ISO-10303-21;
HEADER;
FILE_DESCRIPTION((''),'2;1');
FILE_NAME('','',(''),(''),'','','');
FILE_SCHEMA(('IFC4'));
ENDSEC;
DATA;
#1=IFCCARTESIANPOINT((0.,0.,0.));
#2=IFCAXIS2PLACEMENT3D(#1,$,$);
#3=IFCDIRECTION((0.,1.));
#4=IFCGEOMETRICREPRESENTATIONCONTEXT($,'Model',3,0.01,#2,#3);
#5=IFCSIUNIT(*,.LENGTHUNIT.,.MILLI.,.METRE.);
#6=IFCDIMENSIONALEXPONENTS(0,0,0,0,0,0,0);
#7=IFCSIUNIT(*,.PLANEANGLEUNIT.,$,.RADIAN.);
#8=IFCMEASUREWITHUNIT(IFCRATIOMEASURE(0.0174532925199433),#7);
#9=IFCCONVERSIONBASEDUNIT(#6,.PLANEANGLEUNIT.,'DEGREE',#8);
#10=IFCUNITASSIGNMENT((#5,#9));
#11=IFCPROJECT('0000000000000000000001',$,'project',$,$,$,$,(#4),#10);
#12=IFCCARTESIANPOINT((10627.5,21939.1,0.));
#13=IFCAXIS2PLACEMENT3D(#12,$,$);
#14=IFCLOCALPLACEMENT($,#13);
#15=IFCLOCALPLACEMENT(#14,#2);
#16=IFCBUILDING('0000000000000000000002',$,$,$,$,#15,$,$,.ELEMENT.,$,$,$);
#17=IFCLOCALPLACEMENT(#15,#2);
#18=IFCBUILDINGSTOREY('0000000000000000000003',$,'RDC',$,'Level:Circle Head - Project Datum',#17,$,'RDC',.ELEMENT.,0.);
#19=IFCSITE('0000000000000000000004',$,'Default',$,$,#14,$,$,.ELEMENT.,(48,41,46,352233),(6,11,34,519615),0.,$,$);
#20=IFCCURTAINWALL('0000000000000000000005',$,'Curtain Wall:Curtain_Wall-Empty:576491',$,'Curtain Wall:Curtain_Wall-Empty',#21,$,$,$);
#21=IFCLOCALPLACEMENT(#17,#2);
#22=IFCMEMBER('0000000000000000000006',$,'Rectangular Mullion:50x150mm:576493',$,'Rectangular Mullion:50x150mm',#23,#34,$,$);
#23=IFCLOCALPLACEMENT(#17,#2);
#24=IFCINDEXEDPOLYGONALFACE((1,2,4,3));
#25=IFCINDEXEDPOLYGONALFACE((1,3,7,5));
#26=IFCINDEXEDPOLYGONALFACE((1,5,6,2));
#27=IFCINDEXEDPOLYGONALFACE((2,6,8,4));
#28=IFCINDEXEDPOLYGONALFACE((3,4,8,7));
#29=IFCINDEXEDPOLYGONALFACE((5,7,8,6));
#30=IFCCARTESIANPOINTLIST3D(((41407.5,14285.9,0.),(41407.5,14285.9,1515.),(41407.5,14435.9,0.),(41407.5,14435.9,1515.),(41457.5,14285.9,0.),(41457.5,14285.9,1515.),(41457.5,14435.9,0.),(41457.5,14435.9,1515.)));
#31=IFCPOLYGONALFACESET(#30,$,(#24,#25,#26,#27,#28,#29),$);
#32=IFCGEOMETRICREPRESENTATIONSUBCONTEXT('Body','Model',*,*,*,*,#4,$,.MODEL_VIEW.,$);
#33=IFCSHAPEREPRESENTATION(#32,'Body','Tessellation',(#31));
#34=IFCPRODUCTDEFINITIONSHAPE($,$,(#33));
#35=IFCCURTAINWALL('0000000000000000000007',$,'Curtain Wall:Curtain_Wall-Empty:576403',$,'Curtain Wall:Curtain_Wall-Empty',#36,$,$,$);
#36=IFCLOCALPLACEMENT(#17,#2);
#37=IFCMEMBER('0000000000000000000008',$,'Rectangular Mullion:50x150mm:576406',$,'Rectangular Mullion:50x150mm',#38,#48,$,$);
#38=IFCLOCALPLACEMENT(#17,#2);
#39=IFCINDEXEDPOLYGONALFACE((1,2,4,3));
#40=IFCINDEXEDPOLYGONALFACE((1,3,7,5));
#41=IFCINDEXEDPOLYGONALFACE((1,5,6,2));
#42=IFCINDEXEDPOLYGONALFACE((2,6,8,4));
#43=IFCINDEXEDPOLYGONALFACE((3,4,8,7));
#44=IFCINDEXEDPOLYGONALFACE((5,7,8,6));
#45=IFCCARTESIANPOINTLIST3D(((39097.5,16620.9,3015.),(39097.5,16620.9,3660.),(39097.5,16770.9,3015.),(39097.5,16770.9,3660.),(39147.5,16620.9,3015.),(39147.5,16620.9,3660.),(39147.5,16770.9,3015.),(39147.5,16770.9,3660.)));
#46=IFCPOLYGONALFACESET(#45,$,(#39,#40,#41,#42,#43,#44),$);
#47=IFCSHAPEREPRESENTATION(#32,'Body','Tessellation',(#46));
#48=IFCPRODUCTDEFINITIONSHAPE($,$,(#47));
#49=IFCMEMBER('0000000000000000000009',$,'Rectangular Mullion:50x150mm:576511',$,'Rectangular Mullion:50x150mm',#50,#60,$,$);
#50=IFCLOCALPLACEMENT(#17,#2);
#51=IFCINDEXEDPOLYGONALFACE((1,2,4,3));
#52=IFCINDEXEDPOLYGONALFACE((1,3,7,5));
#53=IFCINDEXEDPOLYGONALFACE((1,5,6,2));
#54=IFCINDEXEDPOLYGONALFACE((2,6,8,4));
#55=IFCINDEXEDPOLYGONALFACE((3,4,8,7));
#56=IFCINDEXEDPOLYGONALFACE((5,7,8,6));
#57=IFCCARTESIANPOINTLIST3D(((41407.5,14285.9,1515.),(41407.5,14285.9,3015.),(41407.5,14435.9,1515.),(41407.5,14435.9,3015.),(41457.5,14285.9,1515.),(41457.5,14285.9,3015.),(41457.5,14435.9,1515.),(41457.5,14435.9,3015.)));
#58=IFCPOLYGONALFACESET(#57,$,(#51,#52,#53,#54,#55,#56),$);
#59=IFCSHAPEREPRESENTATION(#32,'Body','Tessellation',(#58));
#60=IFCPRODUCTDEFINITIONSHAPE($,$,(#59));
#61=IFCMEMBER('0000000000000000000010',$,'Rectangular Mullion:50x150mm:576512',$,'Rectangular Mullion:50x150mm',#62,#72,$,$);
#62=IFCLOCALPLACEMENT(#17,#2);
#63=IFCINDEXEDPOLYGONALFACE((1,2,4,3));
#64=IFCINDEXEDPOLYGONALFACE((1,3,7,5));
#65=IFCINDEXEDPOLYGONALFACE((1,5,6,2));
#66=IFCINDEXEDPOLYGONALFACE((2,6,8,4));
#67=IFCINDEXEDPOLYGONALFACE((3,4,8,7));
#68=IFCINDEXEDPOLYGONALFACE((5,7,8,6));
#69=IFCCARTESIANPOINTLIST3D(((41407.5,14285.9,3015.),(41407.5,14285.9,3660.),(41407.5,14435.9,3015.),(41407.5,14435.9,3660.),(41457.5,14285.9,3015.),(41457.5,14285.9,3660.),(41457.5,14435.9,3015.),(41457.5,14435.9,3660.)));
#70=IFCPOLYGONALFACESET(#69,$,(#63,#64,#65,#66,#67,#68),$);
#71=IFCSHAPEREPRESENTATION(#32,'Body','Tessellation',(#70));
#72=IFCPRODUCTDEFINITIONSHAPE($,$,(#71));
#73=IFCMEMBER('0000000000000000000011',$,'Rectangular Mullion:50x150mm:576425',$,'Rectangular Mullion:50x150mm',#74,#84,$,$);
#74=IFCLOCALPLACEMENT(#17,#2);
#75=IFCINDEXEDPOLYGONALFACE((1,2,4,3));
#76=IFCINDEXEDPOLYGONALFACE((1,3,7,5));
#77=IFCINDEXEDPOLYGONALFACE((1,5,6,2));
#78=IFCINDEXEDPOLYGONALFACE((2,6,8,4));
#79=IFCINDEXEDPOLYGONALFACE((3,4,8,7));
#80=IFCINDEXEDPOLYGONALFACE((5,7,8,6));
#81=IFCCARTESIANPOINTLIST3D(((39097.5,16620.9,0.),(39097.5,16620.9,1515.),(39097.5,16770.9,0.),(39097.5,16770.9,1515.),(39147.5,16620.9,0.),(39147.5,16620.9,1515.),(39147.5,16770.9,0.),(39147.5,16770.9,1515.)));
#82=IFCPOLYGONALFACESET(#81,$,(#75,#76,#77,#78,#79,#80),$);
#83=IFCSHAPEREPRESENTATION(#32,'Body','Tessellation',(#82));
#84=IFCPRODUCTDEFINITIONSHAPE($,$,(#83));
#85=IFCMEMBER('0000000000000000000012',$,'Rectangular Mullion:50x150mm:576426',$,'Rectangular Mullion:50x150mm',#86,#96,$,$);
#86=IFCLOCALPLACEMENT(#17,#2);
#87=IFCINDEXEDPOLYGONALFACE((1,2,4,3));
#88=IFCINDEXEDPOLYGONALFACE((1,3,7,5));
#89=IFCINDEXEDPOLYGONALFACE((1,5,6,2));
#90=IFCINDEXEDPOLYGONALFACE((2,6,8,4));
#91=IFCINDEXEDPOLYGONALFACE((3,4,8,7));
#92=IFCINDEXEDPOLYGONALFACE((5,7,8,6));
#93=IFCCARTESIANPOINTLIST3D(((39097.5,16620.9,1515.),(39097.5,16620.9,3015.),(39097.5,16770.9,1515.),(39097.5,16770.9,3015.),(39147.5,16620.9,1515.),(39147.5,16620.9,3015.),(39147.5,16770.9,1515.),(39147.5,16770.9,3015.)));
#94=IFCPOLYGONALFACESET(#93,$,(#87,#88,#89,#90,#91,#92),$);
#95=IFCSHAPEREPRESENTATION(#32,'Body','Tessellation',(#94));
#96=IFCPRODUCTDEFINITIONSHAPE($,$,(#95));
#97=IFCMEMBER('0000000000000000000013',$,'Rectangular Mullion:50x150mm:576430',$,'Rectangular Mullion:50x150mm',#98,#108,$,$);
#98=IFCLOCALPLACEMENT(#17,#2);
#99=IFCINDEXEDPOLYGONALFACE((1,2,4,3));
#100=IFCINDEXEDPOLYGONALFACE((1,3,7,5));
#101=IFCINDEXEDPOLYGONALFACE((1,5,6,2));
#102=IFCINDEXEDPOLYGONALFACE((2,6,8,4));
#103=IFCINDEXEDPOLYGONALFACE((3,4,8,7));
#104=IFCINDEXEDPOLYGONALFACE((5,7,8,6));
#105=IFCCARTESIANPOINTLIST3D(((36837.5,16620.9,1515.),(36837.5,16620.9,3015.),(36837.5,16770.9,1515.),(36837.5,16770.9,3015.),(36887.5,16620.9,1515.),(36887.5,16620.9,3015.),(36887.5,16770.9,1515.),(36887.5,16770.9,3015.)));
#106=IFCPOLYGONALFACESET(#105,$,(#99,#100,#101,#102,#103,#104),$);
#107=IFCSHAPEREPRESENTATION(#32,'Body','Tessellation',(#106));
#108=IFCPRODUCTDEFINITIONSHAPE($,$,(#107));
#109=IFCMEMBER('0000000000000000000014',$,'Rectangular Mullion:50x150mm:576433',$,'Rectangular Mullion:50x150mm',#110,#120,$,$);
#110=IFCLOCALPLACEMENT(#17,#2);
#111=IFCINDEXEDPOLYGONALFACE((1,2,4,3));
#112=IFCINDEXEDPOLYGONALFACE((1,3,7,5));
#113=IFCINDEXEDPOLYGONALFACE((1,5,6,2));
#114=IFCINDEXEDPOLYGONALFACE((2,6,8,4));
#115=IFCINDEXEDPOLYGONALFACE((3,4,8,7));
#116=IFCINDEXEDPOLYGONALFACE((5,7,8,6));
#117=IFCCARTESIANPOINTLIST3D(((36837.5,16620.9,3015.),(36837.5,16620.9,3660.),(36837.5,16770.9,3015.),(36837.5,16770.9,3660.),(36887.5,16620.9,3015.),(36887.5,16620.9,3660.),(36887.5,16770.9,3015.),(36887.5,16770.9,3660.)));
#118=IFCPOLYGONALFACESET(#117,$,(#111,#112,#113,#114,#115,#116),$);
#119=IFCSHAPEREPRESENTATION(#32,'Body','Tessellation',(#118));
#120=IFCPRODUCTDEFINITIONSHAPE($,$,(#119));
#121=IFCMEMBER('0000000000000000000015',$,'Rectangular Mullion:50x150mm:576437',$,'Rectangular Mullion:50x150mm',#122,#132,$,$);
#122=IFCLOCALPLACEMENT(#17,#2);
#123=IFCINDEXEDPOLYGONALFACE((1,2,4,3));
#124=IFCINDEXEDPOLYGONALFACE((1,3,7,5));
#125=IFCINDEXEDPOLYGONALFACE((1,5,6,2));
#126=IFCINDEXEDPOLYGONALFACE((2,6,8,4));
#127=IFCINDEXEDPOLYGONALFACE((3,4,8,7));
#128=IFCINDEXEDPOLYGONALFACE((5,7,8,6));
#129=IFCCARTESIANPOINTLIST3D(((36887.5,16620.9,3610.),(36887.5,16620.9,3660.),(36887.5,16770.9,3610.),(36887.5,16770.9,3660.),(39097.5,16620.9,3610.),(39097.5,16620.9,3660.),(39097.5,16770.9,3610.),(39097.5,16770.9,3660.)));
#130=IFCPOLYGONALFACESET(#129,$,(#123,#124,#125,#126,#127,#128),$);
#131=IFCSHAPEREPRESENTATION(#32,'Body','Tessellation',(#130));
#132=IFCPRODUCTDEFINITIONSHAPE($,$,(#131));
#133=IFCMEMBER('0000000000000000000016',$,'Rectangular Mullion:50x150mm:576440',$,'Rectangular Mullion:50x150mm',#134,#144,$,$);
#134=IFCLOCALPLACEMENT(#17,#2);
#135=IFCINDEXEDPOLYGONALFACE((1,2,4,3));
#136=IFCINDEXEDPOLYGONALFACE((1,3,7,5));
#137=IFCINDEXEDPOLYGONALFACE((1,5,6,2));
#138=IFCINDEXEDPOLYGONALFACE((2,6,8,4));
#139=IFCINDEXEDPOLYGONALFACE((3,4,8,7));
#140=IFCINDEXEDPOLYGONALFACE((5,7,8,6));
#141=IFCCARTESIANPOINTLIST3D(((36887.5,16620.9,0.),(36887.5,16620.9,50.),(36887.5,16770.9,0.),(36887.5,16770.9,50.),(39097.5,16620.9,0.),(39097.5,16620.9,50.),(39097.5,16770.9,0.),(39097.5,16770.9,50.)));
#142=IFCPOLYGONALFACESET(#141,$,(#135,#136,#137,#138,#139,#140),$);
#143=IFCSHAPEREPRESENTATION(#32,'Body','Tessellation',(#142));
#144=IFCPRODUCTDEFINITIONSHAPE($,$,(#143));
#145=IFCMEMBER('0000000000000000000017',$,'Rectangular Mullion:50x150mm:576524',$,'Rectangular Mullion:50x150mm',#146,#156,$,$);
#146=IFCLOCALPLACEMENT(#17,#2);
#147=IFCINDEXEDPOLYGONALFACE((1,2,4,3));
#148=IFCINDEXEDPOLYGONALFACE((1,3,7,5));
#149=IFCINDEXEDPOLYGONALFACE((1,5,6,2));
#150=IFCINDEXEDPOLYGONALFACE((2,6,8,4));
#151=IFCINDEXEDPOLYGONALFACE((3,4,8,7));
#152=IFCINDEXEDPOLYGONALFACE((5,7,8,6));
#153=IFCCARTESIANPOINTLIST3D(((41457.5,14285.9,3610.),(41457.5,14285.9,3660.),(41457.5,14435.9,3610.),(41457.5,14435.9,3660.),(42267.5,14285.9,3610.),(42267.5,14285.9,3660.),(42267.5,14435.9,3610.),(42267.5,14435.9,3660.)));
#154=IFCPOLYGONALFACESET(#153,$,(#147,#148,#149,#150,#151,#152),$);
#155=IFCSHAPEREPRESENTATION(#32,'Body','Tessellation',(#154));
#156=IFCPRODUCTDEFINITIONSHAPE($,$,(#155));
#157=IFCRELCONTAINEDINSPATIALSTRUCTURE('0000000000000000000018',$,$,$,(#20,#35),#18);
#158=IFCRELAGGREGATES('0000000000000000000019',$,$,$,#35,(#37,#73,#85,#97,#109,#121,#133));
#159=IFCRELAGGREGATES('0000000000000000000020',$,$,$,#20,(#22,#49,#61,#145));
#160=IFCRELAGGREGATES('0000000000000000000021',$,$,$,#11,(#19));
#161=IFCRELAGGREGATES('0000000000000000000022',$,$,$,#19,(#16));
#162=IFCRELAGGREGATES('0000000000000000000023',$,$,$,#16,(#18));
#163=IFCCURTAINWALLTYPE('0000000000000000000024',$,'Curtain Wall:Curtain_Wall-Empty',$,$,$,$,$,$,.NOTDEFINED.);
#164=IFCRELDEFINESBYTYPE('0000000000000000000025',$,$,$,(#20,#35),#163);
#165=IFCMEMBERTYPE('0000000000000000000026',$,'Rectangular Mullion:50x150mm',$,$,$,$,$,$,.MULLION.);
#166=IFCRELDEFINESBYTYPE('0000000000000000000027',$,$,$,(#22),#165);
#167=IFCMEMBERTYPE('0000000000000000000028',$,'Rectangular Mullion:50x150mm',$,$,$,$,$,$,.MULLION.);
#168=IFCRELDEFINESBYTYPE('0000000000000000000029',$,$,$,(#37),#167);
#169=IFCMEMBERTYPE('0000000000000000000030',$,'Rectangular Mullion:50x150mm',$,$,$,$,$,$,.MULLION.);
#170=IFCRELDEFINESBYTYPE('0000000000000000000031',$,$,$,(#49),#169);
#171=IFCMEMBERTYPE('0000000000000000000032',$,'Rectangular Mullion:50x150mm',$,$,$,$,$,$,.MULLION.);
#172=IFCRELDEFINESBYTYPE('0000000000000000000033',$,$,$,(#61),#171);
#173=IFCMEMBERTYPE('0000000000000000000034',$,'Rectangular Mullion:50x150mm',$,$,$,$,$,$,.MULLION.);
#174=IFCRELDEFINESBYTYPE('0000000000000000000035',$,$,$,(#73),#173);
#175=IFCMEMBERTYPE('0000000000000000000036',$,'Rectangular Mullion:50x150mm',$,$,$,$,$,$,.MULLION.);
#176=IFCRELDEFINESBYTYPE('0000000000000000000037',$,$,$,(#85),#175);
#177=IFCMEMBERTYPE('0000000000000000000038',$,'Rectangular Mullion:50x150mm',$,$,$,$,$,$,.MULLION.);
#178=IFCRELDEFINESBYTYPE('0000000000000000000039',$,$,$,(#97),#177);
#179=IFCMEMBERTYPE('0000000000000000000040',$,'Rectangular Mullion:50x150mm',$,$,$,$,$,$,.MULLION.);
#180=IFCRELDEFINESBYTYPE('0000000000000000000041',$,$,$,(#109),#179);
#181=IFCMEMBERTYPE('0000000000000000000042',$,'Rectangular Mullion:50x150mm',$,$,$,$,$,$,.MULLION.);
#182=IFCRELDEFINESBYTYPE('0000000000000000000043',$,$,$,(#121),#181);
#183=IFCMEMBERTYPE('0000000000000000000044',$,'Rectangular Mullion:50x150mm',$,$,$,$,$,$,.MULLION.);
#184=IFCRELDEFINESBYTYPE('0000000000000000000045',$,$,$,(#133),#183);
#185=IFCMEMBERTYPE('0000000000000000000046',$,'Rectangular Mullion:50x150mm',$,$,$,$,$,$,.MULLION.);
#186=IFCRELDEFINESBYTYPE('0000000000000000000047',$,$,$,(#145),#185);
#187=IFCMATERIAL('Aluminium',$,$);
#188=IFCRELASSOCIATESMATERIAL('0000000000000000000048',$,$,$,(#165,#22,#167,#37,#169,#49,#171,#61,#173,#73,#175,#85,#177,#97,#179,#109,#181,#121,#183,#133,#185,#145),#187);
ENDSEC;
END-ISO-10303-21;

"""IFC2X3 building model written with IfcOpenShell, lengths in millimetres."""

from ifc_helpers import new_model, entity, si_unit, converted_unit, direction, frame, origin, origin_2d_with_axis, place, context, subcontext, project, spatial, rectangle, extrude, source, transform, mapped, material, type_object, type_shapes, element, aggregate, save


model = new_model("IFC2X3")

# Units and contexts
model_context = context("Model", 3, precision=0.01, world=origin(), true_north=direction((0.0, 1.0)))
body_context = subcontext(model_context, "Body", "Model", "MODEL_VIEW")
ifc_project = project(units=[si_unit("LENGTHUNIT", "METRE", prefix="MILLI"), converted_unit("PLANEANGLEUNIT", "DEGREE", entity("IfcRatioMeasure", 0.0174532925199433), si_unit("PLANEANGLEUNIT", "RADIAN"), dimensions=[0, 0, 0, 0, 0, 0, 0])], contexts=[model_context])

# Site, building, storey
site_placement = place(None, frame((10627.5, 21939.1, 0.0)))
site = spatial("IfcSite", under=ifc_project, at=site_placement, Name="Default", CompositionType="ELEMENT", RefLatitude=(48, 41, 46, 352233), RefLongitude=(6, 11, 34, 519615), RefElevation=0.0)
building_placement = place(site_placement, origin())
building = spatial("IfcBuilding", under=site, at=building_placement, CompositionType="ELEMENT")
storey_placement = place(building_placement, origin())
storey = spatial("IfcBuildingStorey", under=building, at=storey_placement, Name="RDC", ObjectType="Level:Circle Head - Project Datum", LongName="RDC", CompositionType="ELEMENT", Elevation=0.0)

# Curtain walls, members
curtain_wall_type = type_object("IfcCurtainWallType", Name="Curtain Wall:Curtain_Wall-Empty", PredefinedType="NOTDEFINED")
curtain_wall_1_placement = place(storey_placement, origin())
curtain_wall_1 = element("IfcCurtainWall", 1, at=curtain_wall_1_placement, inside=storey, type_object=curtain_wall_type, Name="Curtain Wall:Curtain_Wall-Empty:576491", ObjectType="Curtain Wall:Curtain_Wall-Empty")
ifc_material_1 = material(Name="Aluminium")
member_type_1 = type_object("IfcMemberType", Name="Rectangular Mullion:50x150mm", PredefinedType="MULLION", material=ifc_material_1)
shared_shape_1 = source(origin(), body_context, "Body", "SweptSolid", [
    extrude(rectangle(XDim=150.0, YDim=50.0, at=origin_2d_with_axis()), frame((-25.0, 0.0, -1515.0), z_axis=(0.0, 0.0, 1.0), x_axis=(0.0, -1.0, 0.0)), (0.0, 0.0, 1.0), 1515.0),
])
type_shapes(member_type_1, [shared_shape_1])
member_1_placement = place(storey_placement, frame((41407.5, 14360.9, 0.0), z_axis=(0.0, 0.0, -1.0), x_axis=(-1.0, 0.0, 0.0)))
member_1 = element("IfcMember", 2, at=member_1_placement, type_object=member_type_1, material=ifc_material_1, Name="Rectangular Mullion:50x150mm:576493", ObjectType="Rectangular Mullion:50x150mm", context=body_context, shape_type="MappedRepresentation", body=[
    mapped(shared_shape_1, transform((0.0, 0.0, 0.0), scale=1.0)),
])
curtain_wall_2_placement = place(storey_placement, origin())
curtain_wall_2 = element("IfcCurtainWall", 3, at=curtain_wall_2_placement, inside=storey, type_object=curtain_wall_type, Name="Curtain Wall:Curtain_Wall-Empty:576403", ObjectType="Curtain Wall:Curtain_Wall-Empty")
member_type_2 = type_object("IfcMemberType", Name="Rectangular Mullion:50x150mm", PredefinedType="MULLION", material=ifc_material_1)
shared_shape_2 = source(origin(), body_context, "Body", "SweptSolid", [
    extrude(rectangle(XDim=150.0, YDim=50.0, at=origin_2d_with_axis()), frame((-25.0, 0.0, -645.0), z_axis=(0.0, 0.0, 1.0), x_axis=(0.0, -1.0, 0.0)), (0.0, 0.0, 1.0), 645.0),
])
type_shapes(member_type_2, [shared_shape_2])
member_2_placement = place(storey_placement, frame((39147.5, 16695.9, 3660.0)))
member_2 = element("IfcMember", 4, at=member_2_placement, type_object=member_type_2, material=ifc_material_1, Name="Rectangular Mullion:50x150mm:576406", ObjectType="Rectangular Mullion:50x150mm", context=body_context, shape_type="MappedRepresentation", body=[
    mapped(shared_shape_2, transform((0.0, 0.0, 0.0), scale=1.0)),
])

# Members
member_type_3 = type_object("IfcMemberType", Name="Rectangular Mullion:50x150mm", PredefinedType="MULLION", material=ifc_material_1)
shared_shape_3 = source(origin(), body_context, "Body", "SweptSolid", [
    extrude(rectangle(XDim=150.0, YDim=50.0, at=origin_2d_with_axis()), frame((-25.0, 0.0, -1500.0), z_axis=(0.0, 0.0, 1.0), x_axis=(0.0, -1.0, 0.0)), (0.0, 0.0, 1.0), 1500.0),
])
type_shapes(member_type_3, [shared_shape_3])
member_3_placement = place(storey_placement, frame((41407.5, 14360.9, 1515.0), z_axis=(0.0, 0.0, -1.0), x_axis=(-1.0, 0.0, 0.0)))
member_3 = element("IfcMember", 5, at=member_3_placement, type_object=member_type_3, material=ifc_material_1, Name="Rectangular Mullion:50x150mm:576511", ObjectType="Rectangular Mullion:50x150mm", context=body_context, shape_type="MappedRepresentation", body=[
    mapped(shared_shape_3, transform((0.0, 0.0, 0.0), scale=1.0)),
])
member_type_4 = type_object("IfcMemberType", Name="Rectangular Mullion:50x150mm", PredefinedType="MULLION", material=ifc_material_1)
shared_shape_4 = source(origin(), body_context, "Body", "SweptSolid", [
    extrude(rectangle(XDim=150.0, YDim=50.0, at=origin_2d_with_axis()), frame((-25.0, 0.0, -645.0), z_axis=(0.0, 0.0, 1.0), x_axis=(0.0, -1.0, 0.0)), (0.0, 0.0, 1.0), 645.0),
])
type_shapes(member_type_4, [shared_shape_4])
member_4_placement = place(storey_placement, frame((41407.5, 14360.9, 3015.0), z_axis=(0.0, 0.0, -1.0), x_axis=(-1.0, 0.0, 0.0)))
member_4 = element("IfcMember", 6, at=member_4_placement, type_object=member_type_4, material=ifc_material_1, Name="Rectangular Mullion:50x150mm:576512", ObjectType="Rectangular Mullion:50x150mm", context=body_context, shape_type="MappedRepresentation", body=[
    mapped(shared_shape_4, transform((0.0, 0.0, 0.0), scale=1.0)),
])
member_type_5 = type_object("IfcMemberType", Name="Rectangular Mullion:50x150mm", PredefinedType="MULLION", material=ifc_material_1)
shared_shape_5 = source(origin(), body_context, "Body", "SweptSolid", [
    extrude(rectangle(XDim=150.0, YDim=50.0, at=origin_2d_with_axis()), frame((-25.0, 0.0, -1515.0), z_axis=(0.0, 0.0, 1.0), x_axis=(0.0, -1.0, 0.0)), (0.0, 0.0, 1.0), 1515.0),
])
type_shapes(member_type_5, [shared_shape_5])
member_5_placement = place(storey_placement, frame((39147.5, 16695.9, 1515.0)))
member_5 = element("IfcMember", 7, at=member_5_placement, type_object=member_type_5, material=ifc_material_1, Name="Rectangular Mullion:50x150mm:576425", ObjectType="Rectangular Mullion:50x150mm", context=body_context, shape_type="MappedRepresentation", body=[
    mapped(shared_shape_5, transform((0.0, 0.0, 0.0), scale=1.0)),
])
member_type_6 = type_object("IfcMemberType", Name="Rectangular Mullion:50x150mm", PredefinedType="MULLION", material=ifc_material_1)
shared_shape_6 = source(origin(), body_context, "Body", "SweptSolid", [
    extrude(rectangle(XDim=150.0, YDim=50.0, at=origin_2d_with_axis()), frame((-25.0, 0.0, -1500.0), z_axis=(0.0, 0.0, 1.0), x_axis=(0.0, -1.0, 0.0)), (0.0, 0.0, 1.0), 1500.0),
])
type_shapes(member_type_6, [shared_shape_6])
member_6_placement = place(storey_placement, frame((39147.5, 16695.9, 3015.0)))
member_6 = element("IfcMember", 8, at=member_6_placement, type_object=member_type_6, material=ifc_material_1, Name="Rectangular Mullion:50x150mm:576426", ObjectType="Rectangular Mullion:50x150mm", context=body_context, shape_type="MappedRepresentation", body=[
    mapped(shared_shape_6, transform((0.0, 0.0, 0.0), scale=1.0)),
])
member_type_7 = type_object("IfcMemberType", Name="Rectangular Mullion:50x150mm", PredefinedType="MULLION", material=ifc_material_1)
shared_shape_7 = source(origin(), body_context, "Body", "SweptSolid", [
    extrude(rectangle(XDim=150.0, YDim=50.0, at=origin_2d_with_axis()), frame((0.0, 0.0, -1500.0), z_axis=(0.0, 0.0, 1.0), x_axis=(0.0, -1.0, 0.0)), (0.0, 0.0, 1.0), 1500.0),
])
type_shapes(member_type_7, [shared_shape_7])
member_7_placement = place(storey_placement, frame((36862.5, 16695.9, 1515.0), z_axis=(0.0, 0.0, -1.0), x_axis=(-1.0, 0.0, 0.0)))
member_7 = element("IfcMember", 9, at=member_7_placement, type_object=member_type_7, material=ifc_material_1, Name="Rectangular Mullion:50x150mm:576430", ObjectType="Rectangular Mullion:50x150mm", context=body_context, shape_type="MappedRepresentation", body=[
    mapped(shared_shape_7, transform((0.0, 0.0, 0.0), scale=1.0)),
])
member_type_8 = type_object("IfcMemberType", Name="Rectangular Mullion:50x150mm", PredefinedType="MULLION", material=ifc_material_1)
shared_shape_8 = source(origin(), body_context, "Body", "SweptSolid", [
    extrude(rectangle(XDim=150.0, YDim=50.0, at=origin_2d_with_axis()), frame((0.0, 0.0, -645.0), z_axis=(0.0, 0.0, 1.0), x_axis=(0.0, -1.0, 0.0)), (0.0, 0.0, 1.0), 645.0),
])
type_shapes(member_type_8, [shared_shape_8])
member_8_placement = place(storey_placement, frame((36862.5, 16695.9, 3015.0), z_axis=(0.0, 0.0, -1.0), x_axis=(-1.0, 0.0, 0.0)))
member_8 = element("IfcMember", 10, at=member_8_placement, type_object=member_type_8, material=ifc_material_1, Name="Rectangular Mullion:50x150mm:576433", ObjectType="Rectangular Mullion:50x150mm", context=body_context, shape_type="MappedRepresentation", body=[
    mapped(shared_shape_8, transform((0.0, 0.0, 0.0), scale=1.0)),
])
member_type_9 = type_object("IfcMemberType", Name="Rectangular Mullion:50x150mm", PredefinedType="MULLION", material=ifc_material_1)
shared_shape_9 = source(origin(), body_context, "Body", "SweptSolid", [
    extrude(rectangle(XDim=150.0, YDim=50.0, at=origin_2d_with_axis()), frame((-25.0, 0.0, -2210.0), z_axis=(0.0, 0.0, 1.0), x_axis=(0.0, -1.0, 0.0)), (0.0, 0.0, 1.0), 2210.0),
])
type_shapes(member_type_9, [shared_shape_9])
member_9_placement = place(storey_placement, frame((36887.5, 16695.9, 3660.0), z_axis=(-1.0, 0.0, 0.0), x_axis=(0.0, 0.0, 1.0)))
member_9 = element("IfcMember", 11, at=member_9_placement, type_object=member_type_9, material=ifc_material_1, Name="Rectangular Mullion:50x150mm:576437", ObjectType="Rectangular Mullion:50x150mm", context=body_context, shape_type="MappedRepresentation", body=[
    mapped(shared_shape_9, transform((0.0, 0.0, 0.0), scale=1.0)),
])
member_type_10 = type_object("IfcMemberType", Name="Rectangular Mullion:50x150mm", PredefinedType="MULLION", material=ifc_material_1)
shared_shape_10 = source(origin(), body_context, "Body", "SweptSolid", [
    extrude(rectangle(XDim=150.0, YDim=50.0, at=origin_2d_with_axis()), frame((-25.0, 0.0, -2210.0), z_axis=(0.0, 0.0, 1.0), x_axis=(0.0, -1.0, 0.0)), (0.0, 0.0, 1.0), 2210.0),
])
type_shapes(member_type_10, [shared_shape_10])
member_10_placement = place(storey_placement, frame((39097.5, 16695.9, 0.0), z_axis=(1.0, 0.0, 0.0), x_axis=(0.0, 0.0, -1.0)))
member_10 = element("IfcMember", 12, at=member_10_placement, type_object=member_type_10, material=ifc_material_1, Name="Rectangular Mullion:50x150mm:576440", ObjectType="Rectangular Mullion:50x150mm", context=body_context, shape_type="MappedRepresentation", body=[
    mapped(shared_shape_10, transform((0.0, 0.0, 0.0), scale=1.0)),
])
member_type_11 = type_object("IfcMemberType", Name="Rectangular Mullion:50x150mm", PredefinedType="MULLION", material=ifc_material_1)
shared_shape_11 = source(origin(), body_context, "Body", "SweptSolid", [
    extrude(rectangle(XDim=150.0, YDim=50.0, at=origin_2d_with_axis()), frame((-25.0, 0.0, -810.0), z_axis=(0.0, 0.0, 1.0), x_axis=(0.0, -1.0, 0.0)), (0.0, 0.0, 1.0), 810.0),
])
type_shapes(member_type_11, [shared_shape_11])
member_11_placement = place(storey_placement, frame((41457.5, 14360.9, 3660.0), z_axis=(-1.0, 0.0, 0.0), x_axis=(0.0, 0.0, 1.0)))
member_11 = element("IfcMember", 13, at=member_11_placement, type_object=member_type_11, material=ifc_material_1, Name="Rectangular Mullion:50x150mm:576524", ObjectType="Rectangular Mullion:50x150mm", context=body_context, shape_type="MappedRepresentation", body=[
    mapped(shared_shape_11, transform((0.0, 0.0, 0.0), scale=1.0)),
])

aggregate(curtain_wall_2, [member_2, member_5, member_6, member_7, member_8, member_9, member_10])
aggregate(curtain_wall_1, [member_1, member_3, member_4, member_11])

save(model, "model.ifc")
